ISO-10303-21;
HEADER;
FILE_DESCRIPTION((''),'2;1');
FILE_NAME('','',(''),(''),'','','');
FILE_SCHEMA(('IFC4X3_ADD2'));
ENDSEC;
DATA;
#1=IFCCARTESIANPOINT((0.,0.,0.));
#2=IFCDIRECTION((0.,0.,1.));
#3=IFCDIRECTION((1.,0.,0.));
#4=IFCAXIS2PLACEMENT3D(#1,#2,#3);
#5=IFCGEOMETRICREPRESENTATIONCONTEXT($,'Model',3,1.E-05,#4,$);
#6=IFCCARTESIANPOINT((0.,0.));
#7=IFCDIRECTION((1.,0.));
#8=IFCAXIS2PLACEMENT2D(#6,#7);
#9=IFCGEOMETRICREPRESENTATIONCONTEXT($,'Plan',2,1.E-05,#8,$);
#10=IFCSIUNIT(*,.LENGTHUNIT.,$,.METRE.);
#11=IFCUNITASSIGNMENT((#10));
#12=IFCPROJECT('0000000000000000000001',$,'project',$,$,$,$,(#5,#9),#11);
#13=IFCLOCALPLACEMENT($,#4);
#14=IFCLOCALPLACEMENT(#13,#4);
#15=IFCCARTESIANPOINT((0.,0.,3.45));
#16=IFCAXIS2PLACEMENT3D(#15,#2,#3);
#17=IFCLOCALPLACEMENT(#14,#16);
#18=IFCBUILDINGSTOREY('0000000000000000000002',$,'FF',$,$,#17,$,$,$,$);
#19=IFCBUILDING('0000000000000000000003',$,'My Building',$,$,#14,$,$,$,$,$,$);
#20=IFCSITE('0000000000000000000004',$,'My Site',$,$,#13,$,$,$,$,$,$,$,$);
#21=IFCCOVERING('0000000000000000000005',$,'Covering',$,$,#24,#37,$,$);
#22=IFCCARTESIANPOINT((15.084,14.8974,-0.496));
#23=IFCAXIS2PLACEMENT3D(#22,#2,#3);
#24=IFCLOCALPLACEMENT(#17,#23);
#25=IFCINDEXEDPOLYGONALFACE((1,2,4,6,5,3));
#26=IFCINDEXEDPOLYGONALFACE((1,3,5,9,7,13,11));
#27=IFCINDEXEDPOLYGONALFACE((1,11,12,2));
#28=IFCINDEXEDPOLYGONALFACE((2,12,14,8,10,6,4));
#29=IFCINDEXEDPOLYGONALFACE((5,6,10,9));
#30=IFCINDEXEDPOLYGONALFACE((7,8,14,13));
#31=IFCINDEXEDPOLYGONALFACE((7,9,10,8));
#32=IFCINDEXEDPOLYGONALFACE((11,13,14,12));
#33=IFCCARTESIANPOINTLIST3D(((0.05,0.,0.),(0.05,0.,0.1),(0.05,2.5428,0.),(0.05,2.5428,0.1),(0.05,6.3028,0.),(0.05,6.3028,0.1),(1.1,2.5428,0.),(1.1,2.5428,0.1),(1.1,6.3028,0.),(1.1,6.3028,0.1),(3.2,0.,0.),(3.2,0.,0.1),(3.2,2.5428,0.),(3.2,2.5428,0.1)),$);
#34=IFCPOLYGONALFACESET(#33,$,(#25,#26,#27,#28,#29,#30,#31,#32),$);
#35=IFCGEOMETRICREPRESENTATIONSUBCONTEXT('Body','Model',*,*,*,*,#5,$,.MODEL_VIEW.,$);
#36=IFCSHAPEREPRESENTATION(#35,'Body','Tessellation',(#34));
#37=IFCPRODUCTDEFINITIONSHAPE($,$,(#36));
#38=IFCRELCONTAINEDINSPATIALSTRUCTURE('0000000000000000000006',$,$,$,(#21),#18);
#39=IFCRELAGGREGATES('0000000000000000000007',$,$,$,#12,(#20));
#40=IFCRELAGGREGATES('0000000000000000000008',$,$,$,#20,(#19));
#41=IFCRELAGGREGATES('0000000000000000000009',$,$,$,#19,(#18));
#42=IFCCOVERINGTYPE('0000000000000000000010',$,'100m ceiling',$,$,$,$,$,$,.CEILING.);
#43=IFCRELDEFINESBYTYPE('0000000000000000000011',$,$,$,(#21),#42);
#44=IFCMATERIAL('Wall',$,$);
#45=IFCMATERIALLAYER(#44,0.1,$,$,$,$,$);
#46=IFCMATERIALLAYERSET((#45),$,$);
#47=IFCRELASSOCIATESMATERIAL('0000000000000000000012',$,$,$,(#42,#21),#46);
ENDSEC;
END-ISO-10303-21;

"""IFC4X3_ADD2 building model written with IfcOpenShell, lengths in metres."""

from ifc_helpers import new_model, si_unit, frame, origin_with_axes, origin_2d_with_axis, place, context, subcontext, project, spatial, line, indexed_curve, outline, extrude, material, layer, layer_set, layer_usage, type_object, element, save


model = new_model("IFC4X3_ADD2")

# Units and contexts
model_context = context("Model", 3, precision=1e-05, world=origin_with_axes())
plan_context = context("Plan", 2, precision=1e-05, world=origin_2d_with_axis())
body_context = subcontext(model_context, "Body", "Model", "MODEL_VIEW")
ifc_project = project(units=[si_unit("LENGTHUNIT", "METRE")], contexts=[model_context, plan_context])

# Site, building, storey
site_placement = place(None, origin_with_axes())
site = spatial("IfcSite", under=ifc_project, at=site_placement, Name="My Site")
building_placement = place(site_placement, origin_with_axes())
building = spatial("IfcBuilding", under=site, at=building_placement, Name="My Building")
storey_placement = place(building_placement, frame((0.0, 0.0, 3.45), z_axis=(0.0, 0.0, 1.0), x_axis=(1.0, 0.0, 0.0)))
storey = spatial("IfcBuildingStorey", under=building, at=storey_placement, Name="FF")

# Shared definitions
ifc_material_1 = material(Name="Wall")

# Covering
ifc_layer_1 = layer(ifc_material_1, 0.1)
ifc_layer_set_1 = layer_set([ifc_layer_1])
ifc_layer_usage_1 = layer_usage(ifc_layer_set_1, "AXIS3", "POSITIVE", 0.0)
covering_type = type_object("IfcCoveringType", Name="100m ceiling", PredefinedType="CEILING", material=ifc_layer_set_1)
covering_placement = place(storey_placement, frame((15.084, 14.8974, -0.496), z_axis=(0.0, 0.0, 1.0), x_axis=(1.0, 0.0, 0.0)))
element("IfcCovering", 1, at=covering_placement, inside=storey, type_object=covering_type, material=ifc_layer_usage_1, Name="Covering", context=body_context, shape_type="SweptSolid", body=[
    extrude(outline(indexed_curve([(0.05, 6.3028), (0.05, 2.5428), (0.05, 0.0), (3.2, 0.0), (3.2, 2.5428), (1.1, 2.5428), (1.1, 6.3028)], segments=[line(4, 3), line(3, 2), line(2, 1), line(1, 7), line(7, 6), line(6, 5), line(5, 4)], self_intersect=False)), None, (0.0, 0.0, 1.0), 0.1),
])

save(model, "model.ifc")
